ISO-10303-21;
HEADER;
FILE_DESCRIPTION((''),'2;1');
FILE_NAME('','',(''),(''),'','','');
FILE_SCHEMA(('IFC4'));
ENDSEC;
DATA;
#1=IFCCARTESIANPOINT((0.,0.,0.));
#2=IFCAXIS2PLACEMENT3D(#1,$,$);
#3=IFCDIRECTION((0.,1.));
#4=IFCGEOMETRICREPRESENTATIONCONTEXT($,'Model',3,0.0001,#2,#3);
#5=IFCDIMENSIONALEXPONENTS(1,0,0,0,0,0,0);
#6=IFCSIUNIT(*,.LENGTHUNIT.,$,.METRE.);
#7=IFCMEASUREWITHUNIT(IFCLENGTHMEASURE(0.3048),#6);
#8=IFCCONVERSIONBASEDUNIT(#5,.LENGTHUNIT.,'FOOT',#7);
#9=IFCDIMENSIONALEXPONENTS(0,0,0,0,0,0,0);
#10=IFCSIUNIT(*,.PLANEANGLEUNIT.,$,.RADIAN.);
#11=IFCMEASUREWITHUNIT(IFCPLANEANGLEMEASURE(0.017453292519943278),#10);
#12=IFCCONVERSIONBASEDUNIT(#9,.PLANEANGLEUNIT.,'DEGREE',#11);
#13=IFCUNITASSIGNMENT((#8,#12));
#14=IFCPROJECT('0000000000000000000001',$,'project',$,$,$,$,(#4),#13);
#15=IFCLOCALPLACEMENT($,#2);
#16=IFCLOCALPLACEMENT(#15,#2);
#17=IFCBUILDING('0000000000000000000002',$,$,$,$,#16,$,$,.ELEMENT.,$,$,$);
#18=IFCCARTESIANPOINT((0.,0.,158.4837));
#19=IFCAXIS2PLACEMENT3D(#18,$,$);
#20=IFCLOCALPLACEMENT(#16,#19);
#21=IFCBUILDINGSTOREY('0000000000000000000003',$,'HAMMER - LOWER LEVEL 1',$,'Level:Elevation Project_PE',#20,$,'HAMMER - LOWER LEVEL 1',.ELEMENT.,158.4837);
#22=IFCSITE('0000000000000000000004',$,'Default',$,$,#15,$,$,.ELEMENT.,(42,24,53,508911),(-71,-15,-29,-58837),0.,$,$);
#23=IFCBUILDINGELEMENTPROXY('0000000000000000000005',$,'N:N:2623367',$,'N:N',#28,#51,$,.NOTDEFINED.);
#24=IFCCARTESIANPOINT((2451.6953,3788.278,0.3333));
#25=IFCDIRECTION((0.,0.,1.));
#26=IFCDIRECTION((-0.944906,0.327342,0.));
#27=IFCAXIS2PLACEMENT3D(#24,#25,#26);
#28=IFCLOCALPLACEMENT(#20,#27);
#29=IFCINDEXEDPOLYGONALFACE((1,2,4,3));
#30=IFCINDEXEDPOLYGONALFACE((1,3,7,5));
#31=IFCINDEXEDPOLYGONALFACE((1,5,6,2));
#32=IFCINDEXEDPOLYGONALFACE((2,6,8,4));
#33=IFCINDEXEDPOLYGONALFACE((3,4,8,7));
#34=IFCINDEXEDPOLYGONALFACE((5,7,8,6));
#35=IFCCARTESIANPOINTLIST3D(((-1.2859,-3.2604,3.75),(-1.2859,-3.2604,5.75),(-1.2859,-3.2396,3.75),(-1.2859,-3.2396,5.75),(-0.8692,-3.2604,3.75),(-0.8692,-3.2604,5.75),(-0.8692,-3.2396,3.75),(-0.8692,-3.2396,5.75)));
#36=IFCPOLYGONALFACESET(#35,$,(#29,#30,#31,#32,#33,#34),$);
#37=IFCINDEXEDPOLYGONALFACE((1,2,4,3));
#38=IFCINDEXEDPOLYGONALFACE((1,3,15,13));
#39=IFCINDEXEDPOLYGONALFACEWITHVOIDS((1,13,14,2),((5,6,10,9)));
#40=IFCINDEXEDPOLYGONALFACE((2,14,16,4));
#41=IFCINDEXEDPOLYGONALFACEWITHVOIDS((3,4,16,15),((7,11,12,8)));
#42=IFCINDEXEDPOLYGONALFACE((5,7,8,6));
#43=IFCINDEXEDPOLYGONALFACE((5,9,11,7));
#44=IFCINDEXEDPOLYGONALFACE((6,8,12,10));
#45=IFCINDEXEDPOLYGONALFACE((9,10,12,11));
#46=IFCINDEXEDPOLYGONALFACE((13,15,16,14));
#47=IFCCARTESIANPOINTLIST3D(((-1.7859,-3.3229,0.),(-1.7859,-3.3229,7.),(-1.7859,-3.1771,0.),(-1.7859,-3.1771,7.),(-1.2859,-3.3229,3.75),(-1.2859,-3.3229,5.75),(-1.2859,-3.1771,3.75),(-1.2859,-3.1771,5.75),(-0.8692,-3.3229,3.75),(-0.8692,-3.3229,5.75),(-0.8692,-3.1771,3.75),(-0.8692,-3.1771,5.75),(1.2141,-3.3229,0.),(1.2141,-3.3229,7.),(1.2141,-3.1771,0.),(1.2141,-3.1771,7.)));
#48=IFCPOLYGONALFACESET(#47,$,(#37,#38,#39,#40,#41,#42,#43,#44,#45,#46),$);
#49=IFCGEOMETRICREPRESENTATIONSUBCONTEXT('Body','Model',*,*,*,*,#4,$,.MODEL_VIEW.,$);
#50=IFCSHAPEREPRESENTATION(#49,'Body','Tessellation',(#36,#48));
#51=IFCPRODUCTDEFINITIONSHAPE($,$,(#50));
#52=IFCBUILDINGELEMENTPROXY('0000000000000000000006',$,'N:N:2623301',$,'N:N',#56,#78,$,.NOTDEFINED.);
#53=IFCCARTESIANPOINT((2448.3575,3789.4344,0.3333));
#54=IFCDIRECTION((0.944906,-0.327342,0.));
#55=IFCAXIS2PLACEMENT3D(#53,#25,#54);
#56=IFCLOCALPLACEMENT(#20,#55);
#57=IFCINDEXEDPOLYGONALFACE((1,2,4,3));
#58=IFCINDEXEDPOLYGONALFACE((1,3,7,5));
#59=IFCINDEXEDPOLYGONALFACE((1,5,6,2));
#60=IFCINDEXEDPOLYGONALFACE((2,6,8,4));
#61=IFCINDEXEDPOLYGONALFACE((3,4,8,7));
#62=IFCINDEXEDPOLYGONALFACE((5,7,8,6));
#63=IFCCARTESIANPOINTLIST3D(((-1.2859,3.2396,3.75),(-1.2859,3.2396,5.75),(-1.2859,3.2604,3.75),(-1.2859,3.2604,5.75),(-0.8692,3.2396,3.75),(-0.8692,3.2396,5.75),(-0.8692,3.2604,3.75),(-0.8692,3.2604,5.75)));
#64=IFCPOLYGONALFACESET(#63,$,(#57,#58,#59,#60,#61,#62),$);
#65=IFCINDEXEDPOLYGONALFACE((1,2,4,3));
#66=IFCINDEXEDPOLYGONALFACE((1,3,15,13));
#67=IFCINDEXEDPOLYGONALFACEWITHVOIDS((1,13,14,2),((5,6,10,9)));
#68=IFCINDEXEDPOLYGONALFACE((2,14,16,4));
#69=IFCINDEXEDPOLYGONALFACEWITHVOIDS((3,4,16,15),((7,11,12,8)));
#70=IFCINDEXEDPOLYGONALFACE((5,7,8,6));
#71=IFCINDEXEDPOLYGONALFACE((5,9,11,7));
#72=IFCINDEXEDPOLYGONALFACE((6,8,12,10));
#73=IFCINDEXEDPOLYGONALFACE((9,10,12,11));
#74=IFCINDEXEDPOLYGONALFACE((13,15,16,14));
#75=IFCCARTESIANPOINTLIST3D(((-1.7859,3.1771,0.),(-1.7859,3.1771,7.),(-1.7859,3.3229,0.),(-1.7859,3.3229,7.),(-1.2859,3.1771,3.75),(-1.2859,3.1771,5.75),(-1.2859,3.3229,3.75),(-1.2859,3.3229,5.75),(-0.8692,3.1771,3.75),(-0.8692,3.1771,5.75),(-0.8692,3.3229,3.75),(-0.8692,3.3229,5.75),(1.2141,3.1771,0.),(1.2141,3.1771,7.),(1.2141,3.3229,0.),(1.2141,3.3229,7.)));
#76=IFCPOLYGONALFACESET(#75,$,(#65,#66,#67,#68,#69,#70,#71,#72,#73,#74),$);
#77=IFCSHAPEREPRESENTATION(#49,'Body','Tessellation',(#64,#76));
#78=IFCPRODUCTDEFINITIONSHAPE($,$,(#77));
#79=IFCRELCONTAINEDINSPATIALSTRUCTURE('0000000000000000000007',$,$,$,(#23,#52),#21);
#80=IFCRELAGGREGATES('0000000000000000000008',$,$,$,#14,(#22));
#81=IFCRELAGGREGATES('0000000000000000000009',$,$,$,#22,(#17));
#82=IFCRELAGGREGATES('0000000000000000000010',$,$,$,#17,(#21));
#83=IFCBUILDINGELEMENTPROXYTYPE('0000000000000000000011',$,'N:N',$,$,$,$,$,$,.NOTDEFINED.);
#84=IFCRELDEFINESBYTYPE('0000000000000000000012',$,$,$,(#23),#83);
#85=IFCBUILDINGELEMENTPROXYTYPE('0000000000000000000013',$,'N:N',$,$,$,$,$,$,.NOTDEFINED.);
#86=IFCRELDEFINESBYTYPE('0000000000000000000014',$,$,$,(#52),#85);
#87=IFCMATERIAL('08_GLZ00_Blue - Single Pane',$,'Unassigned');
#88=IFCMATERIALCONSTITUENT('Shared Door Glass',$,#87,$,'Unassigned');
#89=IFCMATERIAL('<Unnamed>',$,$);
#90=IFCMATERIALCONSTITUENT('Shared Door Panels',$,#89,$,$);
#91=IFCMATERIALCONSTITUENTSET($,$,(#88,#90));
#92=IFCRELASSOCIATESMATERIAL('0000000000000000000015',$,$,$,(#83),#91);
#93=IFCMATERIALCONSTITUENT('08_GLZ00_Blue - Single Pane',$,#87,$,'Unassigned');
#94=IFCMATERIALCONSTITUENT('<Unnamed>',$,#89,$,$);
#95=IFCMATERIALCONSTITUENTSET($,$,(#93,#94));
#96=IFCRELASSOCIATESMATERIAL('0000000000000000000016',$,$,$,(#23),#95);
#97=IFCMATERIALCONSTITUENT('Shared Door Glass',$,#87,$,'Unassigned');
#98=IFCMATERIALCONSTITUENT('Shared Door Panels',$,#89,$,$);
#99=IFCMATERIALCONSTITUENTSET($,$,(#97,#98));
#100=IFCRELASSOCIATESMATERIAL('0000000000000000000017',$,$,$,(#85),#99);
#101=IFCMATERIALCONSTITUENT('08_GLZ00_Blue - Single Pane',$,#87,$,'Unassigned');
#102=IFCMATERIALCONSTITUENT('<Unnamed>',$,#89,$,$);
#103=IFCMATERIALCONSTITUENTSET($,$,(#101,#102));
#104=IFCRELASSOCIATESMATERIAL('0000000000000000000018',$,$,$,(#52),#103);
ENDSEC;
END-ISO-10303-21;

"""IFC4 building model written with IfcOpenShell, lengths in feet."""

from ifc_helpers import new_model, entity, si_unit, converted_unit, direction, frame, origin, place, context, subcontext, project, spatial, indexed_curve, outline, extrude, source, transform, mapped, material, constituent, constituent_set, type_object, type_shapes, element, save


model = new_model("IFC4")

# Units and contexts
model_context = context("Model", 3, precision=0.0001, world=origin(), true_north=direction((0.0, 1.0)))
body_context = subcontext(model_context, "Body", "Model", "MODEL_VIEW")
ifc_project = project(units=[converted_unit("LENGTHUNIT", "FOOT", entity("IfcLengthMeasure", 0.3048), si_unit("LENGTHUNIT", "METRE"), dimensions=[1, 0, 0, 0, 0, 0, 0]), converted_unit("PLANEANGLEUNIT", "DEGREE", entity("IfcPlaneAngleMeasure", 0.017453292519943278), si_unit("PLANEANGLEUNIT", "RADIAN"), dimensions=[0, 0, 0, 0, 0, 0, 0])], contexts=[model_context])

# Site, building, storey
site_placement = place(None, origin())
site = spatial("IfcSite", under=ifc_project, at=site_placement, Name="Default", CompositionType="ELEMENT", RefLatitude=(42, 24, 53, 508911), RefLongitude=(-71, -15, -29, -58837), RefElevation=0.0)
building_placement = place(site_placement, origin())
building = spatial("IfcBuilding", under=site, at=building_placement, CompositionType="ELEMENT")
storey_placement = place(building_placement, frame((0.0, 0.0, 158.4837)))
storey = spatial("IfcBuildingStorey", under=building, at=storey_placement, Name="HAMMER - LOWER LEVEL 1", ObjectType="Level:Elevation Project_PE", LongName="HAMMER - LOWER LEVEL 1", CompositionType="ELEMENT", Elevation=158.4837)

# Shared definitions
ifc_material_1 = material(Name="<Unnamed>")

# Building element proxies
ifc_material_2 = material(Name="08_GLZ00_Blue - Single Pane", Category="Unassigned")
ifc_constituent_1 = constituent(ifc_material_2, Name="Shared Door Glass", Category="Unassigned")
ifc_constituent_2 = constituent(ifc_material_1, Name="Shared Door Panels")
ifc_constituent_set_1 = constituent_set(constituents=[ifc_constituent_1, ifc_constituent_2])
building_element_proxy_type_1 = type_object("IfcBuildingElementProxyType", Name="N:N", PredefinedType="NOTDEFINED", material=ifc_constituent_set_1)
shared_shape_1 = source(origin(), body_context, "Body", "SweptSolid", [
    extrude(outline(indexed_curve([(-0.2083, -0.0104), (0.2083, -0.0104), (0.2083, 0.0104), (-0.2083, 0.0104), (-0.2083, -0.0104)], self_intersect=False)), frame((-1.0775, -3.25, 3.75), z_axis=(0.0, 0.0, 1.0), x_axis=(-1.0, 0.0, 0.0)), (0.0, 0.0, 1.0), 2.0),
    extrude(outline(indexed_curve([(-3.5, -1.5), (3.5, -1.5), (3.5, 1.5), (-3.5, 1.5), (-3.5, -1.5)], self_intersect=False), holes=[indexed_curve([(-2.25, 0.5833), (-2.25, 1.0), (-0.25, 1.0), (-0.25, 0.5833), (-2.25, 0.5833)], self_intersect=False)]), frame((-0.2859, -3.3229, 3.5), z_axis=(0.0, 1.0, 0.0), x_axis=(0.0, 0.0, -1.0)), (0.0, 0.0, 1.0), 0.1458),
])
type_shapes(building_element_proxy_type_1, [shared_shape_1])
ifc_constituent_3 = constituent(ifc_material_2, Name="08_GLZ00_Blue - Single Pane", Category="Unassigned")
ifc_constituent_4 = constituent(ifc_material_1, Name="<Unnamed>")
ifc_constituent_set_2 = constituent_set(constituents=[ifc_constituent_3, ifc_constituent_4])
proxy_1_placement = place(storey_placement, frame((2451.6953, 3788.278, 0.3333), z_axis=(0.0, 0.0, 1.0), x_axis=(-0.944906, 0.327342, 0.0)))
element("IfcBuildingElementProxy", 1, at=proxy_1_placement, inside=storey, type_object=building_element_proxy_type_1, material=ifc_constituent_set_2, Name="N:N:2623367", ObjectType="N:N", PredefinedType="NOTDEFINED", context=body_context, shape_type="MappedRepresentation", body=[
    mapped(shared_shape_1, transform((0.0, 0.0, 0.0), scale=1.0)),
])
ifc_constituent_5 = constituent(ifc_material_2, Name="08_GLZ00_Blue - Single Pane", Category="Unassigned")
ifc_constituent_6 = constituent(ifc_material_1, Name="<Unnamed>")
ifc_constituent_set_3 = constituent_set(constituents=[ifc_constituent_5, ifc_constituent_6])
ifc_constituent_7 = constituent(ifc_material_2, Name="Shared Door Glass", Category="Unassigned")
ifc_constituent_8 = constituent(ifc_material_1, Name="Shared Door Panels")
ifc_constituent_set_4 = constituent_set(constituents=[ifc_constituent_7, ifc_constituent_8])
building_element_proxy_type_2 = type_object("IfcBuildingElementProxyType", Name="N:N", PredefinedType="NOTDEFINED", material=ifc_constituent_set_4)
shared_shape_2 = source(origin(), body_context, "Body", "SweptSolid", [
    extrude(outline(indexed_curve([(-0.0104, -0.2083), (0.0104, -0.2083), (0.0104, 0.2083), (-0.0104, 0.2083), (-0.0104, -0.2083)], self_intersect=False)), frame((-1.0775, 3.25, 3.75), z_axis=(0.0, 0.0, 1.0), x_axis=(0.0, 1.0, 0.0)), (0.0, 0.0, 1.0), 2.0),
    extrude(outline(indexed_curve([(-3.5, -1.5), (3.5, -1.5), (3.5, 1.5), (-3.5, 1.5), (-3.5, -1.5)], self_intersect=False), holes=[indexed_curve([(-2.25, 0.5833), (-2.25, 1.0), (-0.25, 1.0), (-0.25, 0.5833), (-2.25, 0.5833)], self_intersect=False)]), frame((-0.2859, 3.1771, 3.5), z_axis=(0.0, 1.0, 0.0), x_axis=(0.0, 0.0, -1.0)), (0.0, 0.0, 1.0), 0.1458),
])
type_shapes(building_element_proxy_type_2, [shared_shape_2])
proxy_2_placement = place(storey_placement, frame((2448.3575, 3789.4344, 0.3333), z_axis=(0.0, 0.0, 1.0), x_axis=(0.944906, -0.327342, 0.0)))
element("IfcBuildingElementProxy", 2, at=proxy_2_placement, inside=storey, type_object=building_element_proxy_type_2, material=ifc_constituent_set_3, Name="N:N:2623301", ObjectType="N:N", PredefinedType="NOTDEFINED", context=body_context, shape_type="MappedRepresentation", body=[
    mapped(shared_shape_2, transform((0.0, 0.0, 0.0), scale=1.0)),
])

save(model, "model.ifc")
